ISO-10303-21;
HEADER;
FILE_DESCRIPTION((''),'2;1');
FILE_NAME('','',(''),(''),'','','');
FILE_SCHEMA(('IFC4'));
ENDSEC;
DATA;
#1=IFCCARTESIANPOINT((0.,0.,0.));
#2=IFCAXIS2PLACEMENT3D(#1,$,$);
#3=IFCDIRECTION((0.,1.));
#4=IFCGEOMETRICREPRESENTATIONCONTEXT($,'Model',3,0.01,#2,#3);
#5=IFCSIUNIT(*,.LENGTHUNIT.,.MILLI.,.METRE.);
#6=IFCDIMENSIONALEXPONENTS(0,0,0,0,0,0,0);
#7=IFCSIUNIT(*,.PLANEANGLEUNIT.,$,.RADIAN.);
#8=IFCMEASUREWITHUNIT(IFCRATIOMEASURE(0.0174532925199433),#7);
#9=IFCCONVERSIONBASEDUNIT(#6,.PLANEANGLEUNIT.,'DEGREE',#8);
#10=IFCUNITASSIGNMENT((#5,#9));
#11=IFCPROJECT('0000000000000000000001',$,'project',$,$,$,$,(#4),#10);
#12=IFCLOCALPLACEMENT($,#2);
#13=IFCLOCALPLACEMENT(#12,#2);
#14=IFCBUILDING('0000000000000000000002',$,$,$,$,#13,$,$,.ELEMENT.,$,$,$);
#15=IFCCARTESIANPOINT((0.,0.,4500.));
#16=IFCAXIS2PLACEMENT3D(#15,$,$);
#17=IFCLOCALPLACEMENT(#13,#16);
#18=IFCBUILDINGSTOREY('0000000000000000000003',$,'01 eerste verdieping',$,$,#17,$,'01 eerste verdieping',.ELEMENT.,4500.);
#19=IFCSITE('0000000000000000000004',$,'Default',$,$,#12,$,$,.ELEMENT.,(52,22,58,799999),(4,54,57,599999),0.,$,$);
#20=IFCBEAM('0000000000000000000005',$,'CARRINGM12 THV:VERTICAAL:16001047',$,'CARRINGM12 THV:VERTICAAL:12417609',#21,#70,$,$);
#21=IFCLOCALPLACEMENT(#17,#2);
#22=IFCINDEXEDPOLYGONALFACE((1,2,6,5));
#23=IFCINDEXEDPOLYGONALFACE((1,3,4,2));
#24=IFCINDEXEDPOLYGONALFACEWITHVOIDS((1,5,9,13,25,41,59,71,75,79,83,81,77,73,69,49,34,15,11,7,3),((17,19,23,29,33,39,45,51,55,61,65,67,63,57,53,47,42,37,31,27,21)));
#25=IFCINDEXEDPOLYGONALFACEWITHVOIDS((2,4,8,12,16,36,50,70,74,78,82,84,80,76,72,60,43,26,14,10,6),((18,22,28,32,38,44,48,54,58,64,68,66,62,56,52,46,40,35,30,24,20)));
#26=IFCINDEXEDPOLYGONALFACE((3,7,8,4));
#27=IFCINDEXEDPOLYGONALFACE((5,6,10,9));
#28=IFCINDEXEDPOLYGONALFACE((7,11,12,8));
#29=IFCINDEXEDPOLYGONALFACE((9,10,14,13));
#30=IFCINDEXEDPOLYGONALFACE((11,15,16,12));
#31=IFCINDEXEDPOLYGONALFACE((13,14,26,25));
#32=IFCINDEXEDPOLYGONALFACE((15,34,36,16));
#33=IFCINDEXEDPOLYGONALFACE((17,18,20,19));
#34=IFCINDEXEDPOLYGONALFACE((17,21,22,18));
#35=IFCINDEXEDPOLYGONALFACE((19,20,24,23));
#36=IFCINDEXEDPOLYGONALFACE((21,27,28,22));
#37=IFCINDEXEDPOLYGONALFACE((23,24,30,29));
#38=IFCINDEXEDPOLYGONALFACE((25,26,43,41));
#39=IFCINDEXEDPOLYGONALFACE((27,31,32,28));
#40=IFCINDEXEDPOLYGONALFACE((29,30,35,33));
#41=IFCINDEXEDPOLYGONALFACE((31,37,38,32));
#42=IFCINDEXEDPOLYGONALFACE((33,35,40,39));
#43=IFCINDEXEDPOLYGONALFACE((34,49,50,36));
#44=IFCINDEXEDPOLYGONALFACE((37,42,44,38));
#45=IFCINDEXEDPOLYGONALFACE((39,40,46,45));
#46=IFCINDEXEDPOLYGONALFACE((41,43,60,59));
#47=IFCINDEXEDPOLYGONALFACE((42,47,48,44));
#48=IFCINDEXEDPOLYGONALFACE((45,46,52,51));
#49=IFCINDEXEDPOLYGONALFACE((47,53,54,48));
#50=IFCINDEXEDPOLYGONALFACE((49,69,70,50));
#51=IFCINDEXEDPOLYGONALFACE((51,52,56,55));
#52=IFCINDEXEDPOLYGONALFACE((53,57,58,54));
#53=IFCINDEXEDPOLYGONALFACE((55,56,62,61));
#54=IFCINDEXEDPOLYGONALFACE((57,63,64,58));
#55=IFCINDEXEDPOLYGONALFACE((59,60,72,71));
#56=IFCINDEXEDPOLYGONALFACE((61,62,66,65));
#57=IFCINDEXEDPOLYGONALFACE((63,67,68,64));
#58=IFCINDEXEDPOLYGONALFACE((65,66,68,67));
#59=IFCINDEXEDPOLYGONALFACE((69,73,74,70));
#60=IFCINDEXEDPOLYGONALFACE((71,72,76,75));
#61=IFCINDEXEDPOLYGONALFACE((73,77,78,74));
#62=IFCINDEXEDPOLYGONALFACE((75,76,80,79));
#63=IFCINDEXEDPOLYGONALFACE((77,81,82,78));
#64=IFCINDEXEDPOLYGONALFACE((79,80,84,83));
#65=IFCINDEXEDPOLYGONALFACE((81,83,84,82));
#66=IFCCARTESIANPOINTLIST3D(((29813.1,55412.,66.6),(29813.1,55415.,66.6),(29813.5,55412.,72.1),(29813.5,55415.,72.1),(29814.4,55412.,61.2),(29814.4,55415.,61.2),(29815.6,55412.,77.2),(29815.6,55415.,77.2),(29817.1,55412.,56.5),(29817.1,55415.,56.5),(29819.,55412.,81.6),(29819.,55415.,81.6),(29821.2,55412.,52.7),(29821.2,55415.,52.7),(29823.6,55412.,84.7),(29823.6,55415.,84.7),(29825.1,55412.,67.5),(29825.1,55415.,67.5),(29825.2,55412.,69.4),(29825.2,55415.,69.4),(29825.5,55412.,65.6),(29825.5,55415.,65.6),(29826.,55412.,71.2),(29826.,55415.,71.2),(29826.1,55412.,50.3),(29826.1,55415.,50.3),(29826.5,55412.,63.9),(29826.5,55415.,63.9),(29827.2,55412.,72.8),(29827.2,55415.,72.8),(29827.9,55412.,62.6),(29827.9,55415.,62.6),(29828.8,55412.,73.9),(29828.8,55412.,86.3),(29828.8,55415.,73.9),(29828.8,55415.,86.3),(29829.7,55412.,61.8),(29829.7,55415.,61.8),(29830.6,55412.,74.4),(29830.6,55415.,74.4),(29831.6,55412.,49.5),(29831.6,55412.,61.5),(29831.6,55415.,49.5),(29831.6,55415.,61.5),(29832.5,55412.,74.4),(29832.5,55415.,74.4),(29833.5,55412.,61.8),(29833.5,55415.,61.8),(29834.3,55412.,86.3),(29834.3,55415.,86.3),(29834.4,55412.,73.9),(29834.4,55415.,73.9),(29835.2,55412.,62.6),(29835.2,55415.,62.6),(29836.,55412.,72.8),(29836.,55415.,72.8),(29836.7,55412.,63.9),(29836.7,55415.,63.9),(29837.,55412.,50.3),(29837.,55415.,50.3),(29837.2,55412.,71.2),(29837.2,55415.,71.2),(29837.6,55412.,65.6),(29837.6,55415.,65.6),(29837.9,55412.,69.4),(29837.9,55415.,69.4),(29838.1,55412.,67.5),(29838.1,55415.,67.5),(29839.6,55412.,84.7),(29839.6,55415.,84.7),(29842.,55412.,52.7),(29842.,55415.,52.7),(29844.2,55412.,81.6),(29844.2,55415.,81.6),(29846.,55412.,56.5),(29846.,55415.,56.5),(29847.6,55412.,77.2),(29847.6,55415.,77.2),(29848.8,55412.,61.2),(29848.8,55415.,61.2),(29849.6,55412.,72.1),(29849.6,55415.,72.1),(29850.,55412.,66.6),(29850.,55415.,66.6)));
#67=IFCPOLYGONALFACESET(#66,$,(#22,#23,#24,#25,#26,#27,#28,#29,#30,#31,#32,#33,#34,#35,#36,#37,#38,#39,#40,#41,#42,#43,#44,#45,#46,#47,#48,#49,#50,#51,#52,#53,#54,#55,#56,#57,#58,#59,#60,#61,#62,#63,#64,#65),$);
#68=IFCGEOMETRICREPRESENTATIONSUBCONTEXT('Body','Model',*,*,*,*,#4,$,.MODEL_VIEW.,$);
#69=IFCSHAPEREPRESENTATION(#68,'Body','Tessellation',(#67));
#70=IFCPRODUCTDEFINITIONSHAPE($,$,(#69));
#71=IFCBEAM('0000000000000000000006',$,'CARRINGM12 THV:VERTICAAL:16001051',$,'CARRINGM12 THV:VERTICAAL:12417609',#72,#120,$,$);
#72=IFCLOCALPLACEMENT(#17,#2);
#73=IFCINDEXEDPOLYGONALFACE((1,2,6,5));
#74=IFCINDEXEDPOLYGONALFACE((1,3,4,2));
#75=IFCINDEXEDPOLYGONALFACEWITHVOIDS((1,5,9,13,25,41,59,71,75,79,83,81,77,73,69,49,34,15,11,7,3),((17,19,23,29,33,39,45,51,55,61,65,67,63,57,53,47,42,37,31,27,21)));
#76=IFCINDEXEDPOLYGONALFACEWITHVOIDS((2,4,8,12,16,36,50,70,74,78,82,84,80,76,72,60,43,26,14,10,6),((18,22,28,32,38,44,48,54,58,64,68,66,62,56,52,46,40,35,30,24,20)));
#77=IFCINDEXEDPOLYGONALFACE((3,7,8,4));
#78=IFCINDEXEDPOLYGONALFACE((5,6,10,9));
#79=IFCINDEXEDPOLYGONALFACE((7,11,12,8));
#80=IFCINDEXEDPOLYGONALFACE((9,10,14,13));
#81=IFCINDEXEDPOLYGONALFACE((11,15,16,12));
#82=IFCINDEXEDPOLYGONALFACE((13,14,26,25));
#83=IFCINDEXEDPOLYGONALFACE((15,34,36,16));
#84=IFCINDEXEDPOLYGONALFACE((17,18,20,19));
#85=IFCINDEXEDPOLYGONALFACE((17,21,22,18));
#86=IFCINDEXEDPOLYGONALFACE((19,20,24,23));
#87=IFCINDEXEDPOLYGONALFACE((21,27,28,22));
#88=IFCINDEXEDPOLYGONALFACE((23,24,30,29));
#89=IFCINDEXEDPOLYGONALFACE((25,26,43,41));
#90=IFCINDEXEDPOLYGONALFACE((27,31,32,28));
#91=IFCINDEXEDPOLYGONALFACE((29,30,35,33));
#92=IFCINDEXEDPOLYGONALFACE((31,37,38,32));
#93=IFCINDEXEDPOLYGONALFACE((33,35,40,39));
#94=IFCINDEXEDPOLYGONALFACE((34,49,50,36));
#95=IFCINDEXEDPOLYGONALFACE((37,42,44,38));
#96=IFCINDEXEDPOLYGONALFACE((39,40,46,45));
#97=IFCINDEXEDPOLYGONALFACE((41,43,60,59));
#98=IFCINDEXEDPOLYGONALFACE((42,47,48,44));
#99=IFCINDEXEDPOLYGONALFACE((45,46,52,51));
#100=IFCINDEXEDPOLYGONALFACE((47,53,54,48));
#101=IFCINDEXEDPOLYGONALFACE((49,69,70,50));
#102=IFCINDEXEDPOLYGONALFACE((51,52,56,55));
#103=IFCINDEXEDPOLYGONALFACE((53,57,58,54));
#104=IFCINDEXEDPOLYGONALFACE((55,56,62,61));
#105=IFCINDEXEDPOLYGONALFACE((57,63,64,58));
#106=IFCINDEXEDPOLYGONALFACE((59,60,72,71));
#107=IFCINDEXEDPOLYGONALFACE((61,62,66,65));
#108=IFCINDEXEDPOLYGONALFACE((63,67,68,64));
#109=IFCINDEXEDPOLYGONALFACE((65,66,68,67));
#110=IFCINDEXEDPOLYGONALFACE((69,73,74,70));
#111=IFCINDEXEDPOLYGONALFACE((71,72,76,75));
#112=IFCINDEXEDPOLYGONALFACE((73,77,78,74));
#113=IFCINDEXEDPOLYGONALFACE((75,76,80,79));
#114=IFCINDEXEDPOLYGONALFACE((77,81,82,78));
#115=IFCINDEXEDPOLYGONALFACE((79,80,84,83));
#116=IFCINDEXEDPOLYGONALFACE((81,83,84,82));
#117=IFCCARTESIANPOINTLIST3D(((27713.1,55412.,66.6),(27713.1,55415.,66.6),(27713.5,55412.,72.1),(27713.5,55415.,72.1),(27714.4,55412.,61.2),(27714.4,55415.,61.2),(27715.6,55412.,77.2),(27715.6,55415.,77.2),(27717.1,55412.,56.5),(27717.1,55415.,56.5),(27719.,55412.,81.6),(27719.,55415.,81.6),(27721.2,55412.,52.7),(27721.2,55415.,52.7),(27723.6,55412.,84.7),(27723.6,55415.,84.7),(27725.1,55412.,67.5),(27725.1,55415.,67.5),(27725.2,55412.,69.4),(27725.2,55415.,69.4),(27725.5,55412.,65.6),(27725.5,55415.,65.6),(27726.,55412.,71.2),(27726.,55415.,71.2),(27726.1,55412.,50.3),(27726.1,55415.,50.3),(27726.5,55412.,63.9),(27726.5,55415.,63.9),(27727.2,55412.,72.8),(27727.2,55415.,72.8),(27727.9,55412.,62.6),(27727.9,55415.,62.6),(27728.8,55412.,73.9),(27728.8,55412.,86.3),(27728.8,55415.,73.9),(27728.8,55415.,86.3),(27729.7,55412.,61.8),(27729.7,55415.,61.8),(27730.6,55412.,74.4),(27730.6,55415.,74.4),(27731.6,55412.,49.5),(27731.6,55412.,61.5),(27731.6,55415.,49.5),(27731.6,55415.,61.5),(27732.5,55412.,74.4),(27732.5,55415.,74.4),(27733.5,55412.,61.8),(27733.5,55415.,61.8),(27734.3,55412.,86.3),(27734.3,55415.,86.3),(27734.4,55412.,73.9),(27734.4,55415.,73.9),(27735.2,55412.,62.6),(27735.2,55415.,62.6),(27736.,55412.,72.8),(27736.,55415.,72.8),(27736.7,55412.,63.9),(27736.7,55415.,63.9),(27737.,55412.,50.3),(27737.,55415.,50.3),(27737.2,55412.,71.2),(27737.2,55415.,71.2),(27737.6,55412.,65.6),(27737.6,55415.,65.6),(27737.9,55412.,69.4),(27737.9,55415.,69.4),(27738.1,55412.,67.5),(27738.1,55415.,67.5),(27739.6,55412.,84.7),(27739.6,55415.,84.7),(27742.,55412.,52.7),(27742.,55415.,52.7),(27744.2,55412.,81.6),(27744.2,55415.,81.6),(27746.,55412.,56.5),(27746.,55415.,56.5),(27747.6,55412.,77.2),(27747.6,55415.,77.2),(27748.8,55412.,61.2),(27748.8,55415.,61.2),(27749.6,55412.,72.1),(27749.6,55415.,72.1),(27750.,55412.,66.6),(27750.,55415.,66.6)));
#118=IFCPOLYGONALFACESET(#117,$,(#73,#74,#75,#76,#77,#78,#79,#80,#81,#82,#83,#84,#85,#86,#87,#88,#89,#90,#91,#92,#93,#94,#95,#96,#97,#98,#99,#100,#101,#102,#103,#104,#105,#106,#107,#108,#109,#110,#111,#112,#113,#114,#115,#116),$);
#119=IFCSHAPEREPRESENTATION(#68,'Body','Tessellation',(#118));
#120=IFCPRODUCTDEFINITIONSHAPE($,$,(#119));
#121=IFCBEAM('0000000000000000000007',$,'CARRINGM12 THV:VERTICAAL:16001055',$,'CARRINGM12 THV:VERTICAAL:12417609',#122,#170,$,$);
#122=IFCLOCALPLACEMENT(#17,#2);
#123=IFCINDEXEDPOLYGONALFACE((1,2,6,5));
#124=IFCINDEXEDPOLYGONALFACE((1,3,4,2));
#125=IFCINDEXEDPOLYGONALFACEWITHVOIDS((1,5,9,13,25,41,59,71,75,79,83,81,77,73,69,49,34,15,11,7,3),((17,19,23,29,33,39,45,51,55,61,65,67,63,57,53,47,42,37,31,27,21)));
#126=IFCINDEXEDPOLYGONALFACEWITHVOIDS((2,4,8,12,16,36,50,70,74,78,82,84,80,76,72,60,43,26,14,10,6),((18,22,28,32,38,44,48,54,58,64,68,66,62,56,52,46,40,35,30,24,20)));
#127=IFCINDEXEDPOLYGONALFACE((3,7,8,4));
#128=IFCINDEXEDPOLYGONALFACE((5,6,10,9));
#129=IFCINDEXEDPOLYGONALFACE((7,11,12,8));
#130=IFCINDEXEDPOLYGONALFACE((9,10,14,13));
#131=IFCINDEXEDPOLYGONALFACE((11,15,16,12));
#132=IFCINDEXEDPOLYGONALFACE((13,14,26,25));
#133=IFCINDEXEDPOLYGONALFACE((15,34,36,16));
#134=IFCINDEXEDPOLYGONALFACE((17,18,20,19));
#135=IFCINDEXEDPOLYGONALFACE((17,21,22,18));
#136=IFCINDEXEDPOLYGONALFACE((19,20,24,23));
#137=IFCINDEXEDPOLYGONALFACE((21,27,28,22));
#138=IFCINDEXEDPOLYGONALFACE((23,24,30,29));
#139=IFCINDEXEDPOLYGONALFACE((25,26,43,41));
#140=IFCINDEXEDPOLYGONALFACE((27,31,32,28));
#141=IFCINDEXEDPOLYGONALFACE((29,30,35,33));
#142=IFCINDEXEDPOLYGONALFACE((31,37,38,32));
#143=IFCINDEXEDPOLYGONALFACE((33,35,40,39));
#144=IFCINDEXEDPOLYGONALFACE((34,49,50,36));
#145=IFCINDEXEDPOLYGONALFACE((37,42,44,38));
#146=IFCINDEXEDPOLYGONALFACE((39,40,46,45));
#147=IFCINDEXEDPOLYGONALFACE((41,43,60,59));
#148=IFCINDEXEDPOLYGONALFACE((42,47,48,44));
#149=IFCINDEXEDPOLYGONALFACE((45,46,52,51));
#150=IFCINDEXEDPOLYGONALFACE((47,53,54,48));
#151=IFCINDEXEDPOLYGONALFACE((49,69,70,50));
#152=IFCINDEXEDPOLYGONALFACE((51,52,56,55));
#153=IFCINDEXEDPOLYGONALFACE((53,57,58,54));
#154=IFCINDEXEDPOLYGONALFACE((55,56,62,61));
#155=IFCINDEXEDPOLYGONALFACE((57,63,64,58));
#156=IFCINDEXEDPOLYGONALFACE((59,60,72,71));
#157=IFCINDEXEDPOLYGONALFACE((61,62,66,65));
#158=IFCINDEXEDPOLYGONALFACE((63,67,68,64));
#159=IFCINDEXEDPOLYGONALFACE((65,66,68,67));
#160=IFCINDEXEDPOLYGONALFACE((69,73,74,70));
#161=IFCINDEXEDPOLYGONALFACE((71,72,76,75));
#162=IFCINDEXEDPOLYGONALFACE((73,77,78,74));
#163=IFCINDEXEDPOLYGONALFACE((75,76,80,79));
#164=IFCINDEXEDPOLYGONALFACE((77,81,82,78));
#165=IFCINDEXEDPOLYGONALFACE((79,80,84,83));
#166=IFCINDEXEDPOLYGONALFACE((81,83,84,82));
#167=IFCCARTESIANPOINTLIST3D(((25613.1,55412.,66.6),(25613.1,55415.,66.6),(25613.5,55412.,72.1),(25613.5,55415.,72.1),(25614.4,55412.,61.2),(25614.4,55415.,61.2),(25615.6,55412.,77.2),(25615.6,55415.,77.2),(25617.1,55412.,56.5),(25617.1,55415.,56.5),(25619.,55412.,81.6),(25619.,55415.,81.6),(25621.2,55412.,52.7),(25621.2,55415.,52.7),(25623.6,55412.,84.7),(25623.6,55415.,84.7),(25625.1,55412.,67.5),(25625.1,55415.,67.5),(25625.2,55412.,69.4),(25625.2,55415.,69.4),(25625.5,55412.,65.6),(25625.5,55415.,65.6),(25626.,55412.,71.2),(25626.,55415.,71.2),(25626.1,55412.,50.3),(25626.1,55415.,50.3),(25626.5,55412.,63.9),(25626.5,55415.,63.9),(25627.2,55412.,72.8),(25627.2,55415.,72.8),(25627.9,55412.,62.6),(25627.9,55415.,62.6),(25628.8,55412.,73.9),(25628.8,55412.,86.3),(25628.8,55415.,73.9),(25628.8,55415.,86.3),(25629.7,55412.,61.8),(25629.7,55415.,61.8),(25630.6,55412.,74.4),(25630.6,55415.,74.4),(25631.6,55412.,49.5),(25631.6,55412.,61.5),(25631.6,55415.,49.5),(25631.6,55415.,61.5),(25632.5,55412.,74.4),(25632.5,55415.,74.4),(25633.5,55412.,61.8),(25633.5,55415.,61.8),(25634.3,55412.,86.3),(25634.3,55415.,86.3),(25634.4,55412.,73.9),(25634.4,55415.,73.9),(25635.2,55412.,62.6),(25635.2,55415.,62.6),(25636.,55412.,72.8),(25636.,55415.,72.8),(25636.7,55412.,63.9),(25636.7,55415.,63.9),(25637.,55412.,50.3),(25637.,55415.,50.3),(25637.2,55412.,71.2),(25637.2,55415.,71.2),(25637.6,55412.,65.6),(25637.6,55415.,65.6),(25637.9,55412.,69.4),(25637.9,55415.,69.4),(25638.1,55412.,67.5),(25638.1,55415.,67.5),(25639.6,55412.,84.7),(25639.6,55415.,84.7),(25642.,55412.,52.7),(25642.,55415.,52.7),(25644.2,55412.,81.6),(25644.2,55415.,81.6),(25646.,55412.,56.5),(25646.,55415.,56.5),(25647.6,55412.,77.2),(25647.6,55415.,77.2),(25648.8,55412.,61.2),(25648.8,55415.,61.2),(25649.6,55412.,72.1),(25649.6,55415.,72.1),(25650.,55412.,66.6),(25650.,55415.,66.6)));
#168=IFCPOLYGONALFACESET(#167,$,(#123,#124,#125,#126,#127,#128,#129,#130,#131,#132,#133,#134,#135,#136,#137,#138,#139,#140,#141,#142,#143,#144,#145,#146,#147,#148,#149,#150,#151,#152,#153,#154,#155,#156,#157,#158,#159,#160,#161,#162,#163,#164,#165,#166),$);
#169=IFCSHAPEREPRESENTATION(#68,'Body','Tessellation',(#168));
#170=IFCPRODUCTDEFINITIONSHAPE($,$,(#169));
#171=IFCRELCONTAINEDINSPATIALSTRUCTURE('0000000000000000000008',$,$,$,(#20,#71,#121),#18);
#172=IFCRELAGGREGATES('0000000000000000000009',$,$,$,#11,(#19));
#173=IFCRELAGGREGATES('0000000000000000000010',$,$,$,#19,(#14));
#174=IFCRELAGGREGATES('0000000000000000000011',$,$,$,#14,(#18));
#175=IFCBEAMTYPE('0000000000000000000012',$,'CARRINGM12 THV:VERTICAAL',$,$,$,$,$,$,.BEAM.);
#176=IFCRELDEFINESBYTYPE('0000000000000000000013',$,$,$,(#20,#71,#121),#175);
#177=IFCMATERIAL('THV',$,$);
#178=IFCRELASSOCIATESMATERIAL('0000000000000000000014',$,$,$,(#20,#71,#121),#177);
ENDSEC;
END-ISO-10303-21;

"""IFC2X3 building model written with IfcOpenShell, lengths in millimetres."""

from ifc_helpers import new_model, entity, si_unit, converted_unit, direction, frame, origin, origin_2d_with_axis, place, context, subcontext, project, spatial, hollow_circle, extrude, material, type_object, element, save


model = new_model("IFC2X3")

# Units and contexts
model_context = context("Model", 3, precision=0.01, world=origin(), true_north=direction((0.0, 1.0)))
body_context = subcontext(model_context, "Body", "Model", "MODEL_VIEW")
ifc_project = project(units=[si_unit("LENGTHUNIT", "METRE", prefix="MILLI"), converted_unit("PLANEANGLEUNIT", "DEGREE", entity("IfcRatioMeasure", 0.0174532925199433), si_unit("PLANEANGLEUNIT", "RADIAN"), dimensions=[0, 0, 0, 0, 0, 0, 0])], contexts=[model_context])

# Site, building, storey
site_placement = place(None, origin())
site = spatial("IfcSite", under=ifc_project, at=site_placement, Name="Default", CompositionType="ELEMENT", RefLatitude=(52, 22, 58, 799999), RefLongitude=(4, 54, 57, 599999), RefElevation=0.0)
building_placement = place(site_placement, origin())
building = spatial("IfcBuilding", under=site, at=building_placement, CompositionType="ELEMENT")
storey_placement = place(building_placement, frame((0.0, 0.0, 4500.0)))
storey = spatial("IfcBuildingStorey", under=building, at=storey_placement, Name="01 eerste verdieping", LongName="01 eerste verdieping", CompositionType="ELEMENT", Elevation=4500.0)

# Beams
ifc_material_1 = material(Name="THV")
beam_type_1 = type_object("IfcBeamType", Name="CARRINGM12 THV:VERTICAAL", PredefinedType="BEAM")
beam_1_placement = place(storey_placement, origin())
element("IfcBeam", 1, at=beam_1_placement, inside=storey, type_object=beam_type_1, material=ifc_material_1, Name="CARRINGM12 THV:VERTICAAL:16001047", ObjectType="CARRINGM12 THV:VERTICAAL:12417609", context=body_context, shape_type="SweptSolid", body=[
    extrude(hollow_circle(Radius=18.5, WallThickness=12.0, at=origin_2d_with_axis()), frame((29831.6, 55412.0, 68.0), z_axis=(0.0, 1.0, 0.0), x_axis=(0.0, 0.0, -1.0)), (0.0, 0.0, 1.0), 3.0),
])
beam_2_placement = place(storey_placement, origin())
element("IfcBeam", 2, at=beam_2_placement, inside=storey, type_object=beam_type_1, material=ifc_material_1, Name="CARRINGM12 THV:VERTICAAL:16001051", ObjectType="CARRINGM12 THV:VERTICAAL:12417609", context=body_context, shape_type="SweptSolid", body=[
    extrude(hollow_circle(Radius=18.5, WallThickness=12.0, at=origin_2d_with_axis()), frame((27731.6, 55412.0, 68.0), z_axis=(0.0, 1.0, 0.0), x_axis=(0.0, 0.0, -1.0)), (0.0, 0.0, 1.0), 3.0),
])
beam_3_placement = place(storey_placement, origin())
element("IfcBeam", 3, at=beam_3_placement, inside=storey, type_object=beam_type_1, material=ifc_material_1, Name="CARRINGM12 THV:VERTICAAL:16001055", ObjectType="CARRINGM12 THV:VERTICAAL:12417609", context=body_context, shape_type="SweptSolid", body=[
    extrude(hollow_circle(Radius=18.5, WallThickness=12.0, at=origin_2d_with_axis()), frame((25631.6, 55412.0, 68.0), z_axis=(0.0, 1.0, 0.0), x_axis=(0.0, 0.0, -1.0)), (0.0, 0.0, 1.0), 3.0),
])

save(model, "model.ifc")
